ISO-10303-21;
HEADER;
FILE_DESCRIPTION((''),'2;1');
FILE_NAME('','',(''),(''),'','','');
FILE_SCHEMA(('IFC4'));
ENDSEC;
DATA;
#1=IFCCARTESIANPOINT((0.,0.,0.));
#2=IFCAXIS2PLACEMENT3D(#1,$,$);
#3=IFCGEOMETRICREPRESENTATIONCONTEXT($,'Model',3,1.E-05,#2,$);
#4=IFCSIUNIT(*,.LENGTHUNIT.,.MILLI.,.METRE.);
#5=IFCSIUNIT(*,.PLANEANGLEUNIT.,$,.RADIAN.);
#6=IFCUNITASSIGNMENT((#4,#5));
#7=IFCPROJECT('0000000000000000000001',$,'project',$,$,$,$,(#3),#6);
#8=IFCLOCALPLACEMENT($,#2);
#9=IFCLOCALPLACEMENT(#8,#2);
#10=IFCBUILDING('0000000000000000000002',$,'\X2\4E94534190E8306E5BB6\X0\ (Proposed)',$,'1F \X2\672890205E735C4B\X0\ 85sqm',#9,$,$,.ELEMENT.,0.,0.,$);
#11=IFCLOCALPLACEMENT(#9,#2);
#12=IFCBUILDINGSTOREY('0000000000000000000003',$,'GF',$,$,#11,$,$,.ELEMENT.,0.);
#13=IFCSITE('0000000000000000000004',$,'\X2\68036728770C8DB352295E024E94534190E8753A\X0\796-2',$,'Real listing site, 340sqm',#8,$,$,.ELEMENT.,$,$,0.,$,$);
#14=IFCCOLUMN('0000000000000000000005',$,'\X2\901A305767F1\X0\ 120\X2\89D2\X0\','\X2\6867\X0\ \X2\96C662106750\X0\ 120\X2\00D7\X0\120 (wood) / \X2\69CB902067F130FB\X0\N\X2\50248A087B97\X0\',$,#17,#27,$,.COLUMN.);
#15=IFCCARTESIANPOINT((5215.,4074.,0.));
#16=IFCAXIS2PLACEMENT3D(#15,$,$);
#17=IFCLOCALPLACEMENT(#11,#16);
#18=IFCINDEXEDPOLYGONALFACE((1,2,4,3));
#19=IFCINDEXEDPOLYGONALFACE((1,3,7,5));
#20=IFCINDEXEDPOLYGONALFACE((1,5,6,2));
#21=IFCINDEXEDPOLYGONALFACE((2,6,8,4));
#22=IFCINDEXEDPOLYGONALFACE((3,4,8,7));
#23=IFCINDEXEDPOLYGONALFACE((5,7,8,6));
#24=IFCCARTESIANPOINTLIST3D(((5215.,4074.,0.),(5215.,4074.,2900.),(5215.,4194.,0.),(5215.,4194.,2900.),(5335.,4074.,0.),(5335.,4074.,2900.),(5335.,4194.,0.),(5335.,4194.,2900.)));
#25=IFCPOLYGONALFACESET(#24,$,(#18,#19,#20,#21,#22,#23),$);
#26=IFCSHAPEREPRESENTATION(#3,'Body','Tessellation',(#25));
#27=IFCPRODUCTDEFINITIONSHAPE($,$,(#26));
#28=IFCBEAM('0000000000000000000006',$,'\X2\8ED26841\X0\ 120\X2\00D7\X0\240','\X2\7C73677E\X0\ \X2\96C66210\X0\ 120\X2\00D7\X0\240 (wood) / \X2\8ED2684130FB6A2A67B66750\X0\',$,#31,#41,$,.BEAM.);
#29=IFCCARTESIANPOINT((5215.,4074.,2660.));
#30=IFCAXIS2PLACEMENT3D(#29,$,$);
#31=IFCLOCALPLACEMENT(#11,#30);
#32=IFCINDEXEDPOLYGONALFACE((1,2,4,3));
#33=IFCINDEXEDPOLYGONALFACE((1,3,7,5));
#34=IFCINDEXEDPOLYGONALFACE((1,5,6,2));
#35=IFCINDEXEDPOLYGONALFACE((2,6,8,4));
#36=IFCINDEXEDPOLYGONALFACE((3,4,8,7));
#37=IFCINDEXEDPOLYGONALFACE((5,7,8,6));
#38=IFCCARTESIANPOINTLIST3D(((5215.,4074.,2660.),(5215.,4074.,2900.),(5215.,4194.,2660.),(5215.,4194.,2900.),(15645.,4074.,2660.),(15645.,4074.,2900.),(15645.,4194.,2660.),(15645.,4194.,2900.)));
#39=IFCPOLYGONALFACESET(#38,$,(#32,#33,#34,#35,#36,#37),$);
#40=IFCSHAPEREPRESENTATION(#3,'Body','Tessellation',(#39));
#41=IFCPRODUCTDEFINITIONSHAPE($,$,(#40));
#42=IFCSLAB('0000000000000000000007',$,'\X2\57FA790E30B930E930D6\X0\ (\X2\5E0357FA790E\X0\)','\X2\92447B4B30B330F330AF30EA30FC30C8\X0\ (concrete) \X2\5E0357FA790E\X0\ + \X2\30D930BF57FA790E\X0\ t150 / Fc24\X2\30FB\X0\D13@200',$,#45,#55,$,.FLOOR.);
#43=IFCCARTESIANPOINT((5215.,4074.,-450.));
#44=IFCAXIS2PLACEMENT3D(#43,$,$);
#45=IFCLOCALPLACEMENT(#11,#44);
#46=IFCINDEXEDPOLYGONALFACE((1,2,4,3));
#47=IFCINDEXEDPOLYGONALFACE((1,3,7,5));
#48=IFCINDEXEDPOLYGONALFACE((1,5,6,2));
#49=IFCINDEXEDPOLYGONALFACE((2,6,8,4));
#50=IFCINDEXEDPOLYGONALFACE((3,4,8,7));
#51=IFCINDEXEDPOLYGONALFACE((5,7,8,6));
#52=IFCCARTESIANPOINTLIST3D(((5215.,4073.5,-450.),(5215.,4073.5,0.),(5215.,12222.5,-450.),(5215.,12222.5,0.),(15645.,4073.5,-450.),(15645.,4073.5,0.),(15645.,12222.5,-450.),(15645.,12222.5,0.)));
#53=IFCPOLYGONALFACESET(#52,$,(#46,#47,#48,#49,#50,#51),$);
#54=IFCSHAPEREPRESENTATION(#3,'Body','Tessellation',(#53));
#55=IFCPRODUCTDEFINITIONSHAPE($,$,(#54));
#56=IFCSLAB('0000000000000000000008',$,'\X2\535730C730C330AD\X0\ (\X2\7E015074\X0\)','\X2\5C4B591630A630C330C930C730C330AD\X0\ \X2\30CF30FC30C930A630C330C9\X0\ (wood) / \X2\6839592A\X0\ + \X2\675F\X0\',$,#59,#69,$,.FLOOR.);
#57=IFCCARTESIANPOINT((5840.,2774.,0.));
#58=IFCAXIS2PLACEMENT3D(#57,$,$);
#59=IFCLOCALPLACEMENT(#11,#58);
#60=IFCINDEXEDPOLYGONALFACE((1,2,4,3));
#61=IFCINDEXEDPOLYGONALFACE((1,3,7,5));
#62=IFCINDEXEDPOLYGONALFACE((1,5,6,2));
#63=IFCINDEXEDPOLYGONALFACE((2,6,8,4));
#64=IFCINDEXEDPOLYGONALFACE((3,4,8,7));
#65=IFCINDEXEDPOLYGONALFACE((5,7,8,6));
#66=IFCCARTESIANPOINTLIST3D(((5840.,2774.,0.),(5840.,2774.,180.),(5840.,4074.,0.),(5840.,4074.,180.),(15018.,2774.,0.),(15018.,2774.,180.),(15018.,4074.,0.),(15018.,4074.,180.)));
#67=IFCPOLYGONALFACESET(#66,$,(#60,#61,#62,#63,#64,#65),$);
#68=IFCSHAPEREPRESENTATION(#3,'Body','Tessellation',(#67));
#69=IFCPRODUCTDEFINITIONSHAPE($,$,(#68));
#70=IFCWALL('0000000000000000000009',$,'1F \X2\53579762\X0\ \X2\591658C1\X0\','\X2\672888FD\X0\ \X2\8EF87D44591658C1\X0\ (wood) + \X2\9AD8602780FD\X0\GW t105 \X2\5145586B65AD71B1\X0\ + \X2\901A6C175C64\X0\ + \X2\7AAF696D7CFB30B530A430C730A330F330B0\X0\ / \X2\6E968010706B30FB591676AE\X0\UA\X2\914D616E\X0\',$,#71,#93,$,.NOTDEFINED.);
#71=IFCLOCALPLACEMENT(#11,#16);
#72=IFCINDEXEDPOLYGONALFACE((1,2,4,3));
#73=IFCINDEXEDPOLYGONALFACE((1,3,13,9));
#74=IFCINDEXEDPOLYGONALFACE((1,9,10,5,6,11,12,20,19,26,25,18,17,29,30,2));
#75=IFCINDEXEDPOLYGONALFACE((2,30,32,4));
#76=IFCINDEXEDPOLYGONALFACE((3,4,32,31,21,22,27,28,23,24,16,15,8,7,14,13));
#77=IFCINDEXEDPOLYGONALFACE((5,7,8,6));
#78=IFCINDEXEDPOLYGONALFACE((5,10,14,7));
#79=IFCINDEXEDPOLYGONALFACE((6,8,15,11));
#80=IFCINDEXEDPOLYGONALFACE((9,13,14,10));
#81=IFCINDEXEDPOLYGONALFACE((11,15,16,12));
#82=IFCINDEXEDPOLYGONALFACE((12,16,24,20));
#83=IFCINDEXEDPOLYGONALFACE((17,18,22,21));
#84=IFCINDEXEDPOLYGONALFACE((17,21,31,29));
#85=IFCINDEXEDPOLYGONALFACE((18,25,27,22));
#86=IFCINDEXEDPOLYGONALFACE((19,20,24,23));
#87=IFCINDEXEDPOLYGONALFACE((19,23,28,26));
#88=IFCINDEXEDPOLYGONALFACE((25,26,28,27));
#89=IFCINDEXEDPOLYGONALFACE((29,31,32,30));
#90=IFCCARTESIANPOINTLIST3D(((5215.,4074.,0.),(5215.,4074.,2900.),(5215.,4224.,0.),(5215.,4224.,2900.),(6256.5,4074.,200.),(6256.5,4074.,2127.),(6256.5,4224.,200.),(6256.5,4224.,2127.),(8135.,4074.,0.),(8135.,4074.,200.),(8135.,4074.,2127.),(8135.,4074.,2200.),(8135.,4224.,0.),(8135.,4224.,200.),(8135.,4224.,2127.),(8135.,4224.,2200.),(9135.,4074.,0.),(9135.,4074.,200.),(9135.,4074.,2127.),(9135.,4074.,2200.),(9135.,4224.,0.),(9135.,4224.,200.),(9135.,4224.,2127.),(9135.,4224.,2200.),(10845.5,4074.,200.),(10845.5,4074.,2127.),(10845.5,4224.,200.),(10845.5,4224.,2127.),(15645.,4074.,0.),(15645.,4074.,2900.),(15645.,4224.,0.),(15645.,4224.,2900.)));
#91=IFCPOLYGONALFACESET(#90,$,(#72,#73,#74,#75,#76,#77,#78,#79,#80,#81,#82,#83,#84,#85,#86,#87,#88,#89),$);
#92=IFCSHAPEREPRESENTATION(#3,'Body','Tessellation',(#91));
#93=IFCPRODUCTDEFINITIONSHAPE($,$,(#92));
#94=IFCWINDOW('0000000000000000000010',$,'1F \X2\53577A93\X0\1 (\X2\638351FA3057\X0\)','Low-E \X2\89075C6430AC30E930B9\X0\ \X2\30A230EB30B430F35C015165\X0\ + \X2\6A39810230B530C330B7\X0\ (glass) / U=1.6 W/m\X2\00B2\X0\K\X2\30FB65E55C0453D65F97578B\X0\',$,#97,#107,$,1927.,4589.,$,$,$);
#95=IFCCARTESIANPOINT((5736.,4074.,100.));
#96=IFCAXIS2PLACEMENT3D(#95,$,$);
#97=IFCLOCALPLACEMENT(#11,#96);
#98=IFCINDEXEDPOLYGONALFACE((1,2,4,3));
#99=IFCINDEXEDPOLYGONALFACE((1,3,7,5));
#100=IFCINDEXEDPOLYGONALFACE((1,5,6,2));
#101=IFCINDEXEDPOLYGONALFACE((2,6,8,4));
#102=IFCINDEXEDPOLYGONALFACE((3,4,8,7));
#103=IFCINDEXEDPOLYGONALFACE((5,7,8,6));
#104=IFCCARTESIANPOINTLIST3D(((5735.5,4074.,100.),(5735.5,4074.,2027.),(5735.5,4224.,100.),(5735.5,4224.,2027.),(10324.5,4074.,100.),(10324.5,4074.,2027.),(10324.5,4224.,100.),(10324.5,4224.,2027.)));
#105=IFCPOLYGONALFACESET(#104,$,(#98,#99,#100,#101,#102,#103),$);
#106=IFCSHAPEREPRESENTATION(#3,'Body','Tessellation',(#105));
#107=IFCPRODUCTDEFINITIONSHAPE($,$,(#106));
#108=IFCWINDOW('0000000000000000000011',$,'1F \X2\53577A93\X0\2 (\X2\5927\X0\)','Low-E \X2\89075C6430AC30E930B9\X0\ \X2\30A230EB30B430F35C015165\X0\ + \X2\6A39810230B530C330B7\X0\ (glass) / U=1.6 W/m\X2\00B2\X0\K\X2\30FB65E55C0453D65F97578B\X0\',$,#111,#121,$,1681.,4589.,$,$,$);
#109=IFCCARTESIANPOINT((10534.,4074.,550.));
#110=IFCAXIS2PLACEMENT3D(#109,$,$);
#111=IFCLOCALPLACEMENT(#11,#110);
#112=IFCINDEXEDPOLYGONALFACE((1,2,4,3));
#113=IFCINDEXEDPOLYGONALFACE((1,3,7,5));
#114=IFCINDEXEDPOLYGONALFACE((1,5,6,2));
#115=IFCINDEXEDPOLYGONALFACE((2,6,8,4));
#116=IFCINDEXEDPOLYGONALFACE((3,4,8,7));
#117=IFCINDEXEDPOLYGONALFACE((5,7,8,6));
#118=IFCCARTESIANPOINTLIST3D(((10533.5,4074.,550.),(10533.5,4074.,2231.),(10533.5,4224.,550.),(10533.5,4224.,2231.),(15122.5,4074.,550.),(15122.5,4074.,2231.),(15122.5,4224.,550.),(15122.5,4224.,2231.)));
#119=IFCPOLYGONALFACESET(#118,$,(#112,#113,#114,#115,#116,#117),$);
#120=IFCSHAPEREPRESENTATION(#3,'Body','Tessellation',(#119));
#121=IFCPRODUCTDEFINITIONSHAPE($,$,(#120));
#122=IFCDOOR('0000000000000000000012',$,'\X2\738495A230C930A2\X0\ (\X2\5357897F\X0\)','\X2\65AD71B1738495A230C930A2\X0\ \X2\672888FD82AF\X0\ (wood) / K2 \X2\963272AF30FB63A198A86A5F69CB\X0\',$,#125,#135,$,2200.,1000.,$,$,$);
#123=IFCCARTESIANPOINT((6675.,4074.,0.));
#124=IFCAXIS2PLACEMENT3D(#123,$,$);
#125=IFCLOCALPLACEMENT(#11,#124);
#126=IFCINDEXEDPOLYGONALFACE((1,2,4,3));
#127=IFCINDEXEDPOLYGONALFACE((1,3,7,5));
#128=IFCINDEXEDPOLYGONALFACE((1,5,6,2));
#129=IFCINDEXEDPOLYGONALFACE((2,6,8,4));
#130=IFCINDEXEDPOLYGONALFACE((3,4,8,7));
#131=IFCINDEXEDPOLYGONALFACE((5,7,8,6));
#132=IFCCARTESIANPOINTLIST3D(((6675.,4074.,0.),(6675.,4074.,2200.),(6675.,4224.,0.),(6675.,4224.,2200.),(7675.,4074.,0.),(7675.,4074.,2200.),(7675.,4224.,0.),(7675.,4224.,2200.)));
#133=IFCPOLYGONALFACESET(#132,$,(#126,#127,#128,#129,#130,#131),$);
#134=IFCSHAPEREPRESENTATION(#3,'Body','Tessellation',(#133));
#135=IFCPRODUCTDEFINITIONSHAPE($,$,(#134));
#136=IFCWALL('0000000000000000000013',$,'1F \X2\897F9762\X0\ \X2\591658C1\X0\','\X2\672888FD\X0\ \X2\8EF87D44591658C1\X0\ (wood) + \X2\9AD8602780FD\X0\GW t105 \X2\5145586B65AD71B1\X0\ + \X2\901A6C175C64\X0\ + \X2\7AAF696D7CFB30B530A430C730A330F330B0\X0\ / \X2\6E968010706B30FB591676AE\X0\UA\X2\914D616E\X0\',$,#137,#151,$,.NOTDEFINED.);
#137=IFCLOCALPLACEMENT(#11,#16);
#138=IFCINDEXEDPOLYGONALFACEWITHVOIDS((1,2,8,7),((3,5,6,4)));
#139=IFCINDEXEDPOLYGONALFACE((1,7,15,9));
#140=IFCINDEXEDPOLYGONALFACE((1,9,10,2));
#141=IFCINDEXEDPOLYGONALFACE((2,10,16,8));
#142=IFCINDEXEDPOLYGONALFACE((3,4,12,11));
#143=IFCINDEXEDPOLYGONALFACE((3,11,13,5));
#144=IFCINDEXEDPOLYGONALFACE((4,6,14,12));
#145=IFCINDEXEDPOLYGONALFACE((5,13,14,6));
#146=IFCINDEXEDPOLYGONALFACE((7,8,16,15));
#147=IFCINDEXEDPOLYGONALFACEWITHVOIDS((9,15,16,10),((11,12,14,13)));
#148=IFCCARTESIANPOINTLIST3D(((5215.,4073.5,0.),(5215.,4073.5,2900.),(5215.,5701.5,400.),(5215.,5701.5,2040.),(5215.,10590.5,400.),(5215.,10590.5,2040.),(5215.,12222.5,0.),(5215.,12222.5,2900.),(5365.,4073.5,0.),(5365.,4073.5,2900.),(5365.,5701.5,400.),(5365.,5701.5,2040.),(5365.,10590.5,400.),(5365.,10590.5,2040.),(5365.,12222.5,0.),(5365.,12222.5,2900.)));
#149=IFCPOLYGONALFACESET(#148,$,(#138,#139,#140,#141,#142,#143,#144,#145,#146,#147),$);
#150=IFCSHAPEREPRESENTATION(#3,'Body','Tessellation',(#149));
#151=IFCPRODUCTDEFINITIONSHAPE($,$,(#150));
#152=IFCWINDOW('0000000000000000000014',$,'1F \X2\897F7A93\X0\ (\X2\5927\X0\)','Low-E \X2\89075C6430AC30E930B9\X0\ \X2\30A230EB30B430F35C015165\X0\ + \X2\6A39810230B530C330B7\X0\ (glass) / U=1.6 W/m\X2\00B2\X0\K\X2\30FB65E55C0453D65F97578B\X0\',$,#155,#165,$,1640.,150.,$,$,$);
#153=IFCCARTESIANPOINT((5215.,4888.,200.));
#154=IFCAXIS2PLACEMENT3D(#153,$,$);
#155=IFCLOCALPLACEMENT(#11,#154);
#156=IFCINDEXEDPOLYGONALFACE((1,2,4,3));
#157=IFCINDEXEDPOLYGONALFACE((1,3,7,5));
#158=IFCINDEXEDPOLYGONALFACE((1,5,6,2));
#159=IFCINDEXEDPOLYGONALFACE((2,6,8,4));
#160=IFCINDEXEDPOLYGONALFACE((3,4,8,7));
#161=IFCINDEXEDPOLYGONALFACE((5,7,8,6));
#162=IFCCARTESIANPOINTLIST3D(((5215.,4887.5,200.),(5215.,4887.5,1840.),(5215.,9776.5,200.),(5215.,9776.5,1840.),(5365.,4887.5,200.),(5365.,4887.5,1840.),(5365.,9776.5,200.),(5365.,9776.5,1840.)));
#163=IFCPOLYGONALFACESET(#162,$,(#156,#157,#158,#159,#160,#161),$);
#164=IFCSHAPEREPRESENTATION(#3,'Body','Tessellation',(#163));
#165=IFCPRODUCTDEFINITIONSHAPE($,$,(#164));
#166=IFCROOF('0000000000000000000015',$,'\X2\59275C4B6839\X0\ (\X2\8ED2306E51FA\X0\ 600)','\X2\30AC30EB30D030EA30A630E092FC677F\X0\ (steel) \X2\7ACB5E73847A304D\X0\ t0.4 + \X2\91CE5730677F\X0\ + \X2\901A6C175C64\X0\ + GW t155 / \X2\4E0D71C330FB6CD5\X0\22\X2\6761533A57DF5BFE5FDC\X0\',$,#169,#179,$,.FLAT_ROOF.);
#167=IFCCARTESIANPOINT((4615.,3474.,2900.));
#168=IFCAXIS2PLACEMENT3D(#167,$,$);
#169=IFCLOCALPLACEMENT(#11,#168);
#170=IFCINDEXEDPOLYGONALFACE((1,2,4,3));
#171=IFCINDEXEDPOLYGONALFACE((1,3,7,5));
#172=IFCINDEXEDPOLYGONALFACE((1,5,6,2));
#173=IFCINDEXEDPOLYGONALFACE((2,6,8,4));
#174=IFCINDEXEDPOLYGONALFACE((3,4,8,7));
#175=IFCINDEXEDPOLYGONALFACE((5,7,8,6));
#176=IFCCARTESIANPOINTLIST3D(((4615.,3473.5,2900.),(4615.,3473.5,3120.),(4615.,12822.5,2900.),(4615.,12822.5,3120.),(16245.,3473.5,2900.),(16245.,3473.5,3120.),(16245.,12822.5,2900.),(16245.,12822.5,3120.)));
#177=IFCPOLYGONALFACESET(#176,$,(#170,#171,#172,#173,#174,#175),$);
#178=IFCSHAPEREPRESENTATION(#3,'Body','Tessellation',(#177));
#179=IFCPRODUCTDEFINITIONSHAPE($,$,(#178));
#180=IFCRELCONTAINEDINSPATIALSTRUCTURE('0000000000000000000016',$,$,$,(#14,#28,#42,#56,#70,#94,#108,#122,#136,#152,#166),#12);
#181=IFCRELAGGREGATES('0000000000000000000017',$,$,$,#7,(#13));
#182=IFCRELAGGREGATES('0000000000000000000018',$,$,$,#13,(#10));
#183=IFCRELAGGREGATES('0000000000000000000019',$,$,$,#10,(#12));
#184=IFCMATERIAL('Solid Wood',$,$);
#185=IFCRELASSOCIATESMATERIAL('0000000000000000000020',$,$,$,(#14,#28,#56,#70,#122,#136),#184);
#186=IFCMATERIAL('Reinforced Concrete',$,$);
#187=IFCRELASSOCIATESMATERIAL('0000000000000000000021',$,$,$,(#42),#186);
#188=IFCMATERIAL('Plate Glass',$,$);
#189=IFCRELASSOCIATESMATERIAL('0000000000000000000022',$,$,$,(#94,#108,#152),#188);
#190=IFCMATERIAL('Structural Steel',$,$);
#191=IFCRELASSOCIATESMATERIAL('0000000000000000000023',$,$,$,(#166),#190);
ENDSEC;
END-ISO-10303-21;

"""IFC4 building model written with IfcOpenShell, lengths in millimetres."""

from ifc_helpers import new_model, si_unit, frame, frame_2d, origin, place, context, project, spatial, rectangle, extrude, material, element, fill, save


model = new_model("IFC4")

# Units and contexts
model_context = context("Model", 3, precision=1e-05, world=origin())
ifc_project = project(units=[si_unit("LENGTHUNIT", "METRE", prefix="MILLI"), si_unit("PLANEANGLEUNIT", "RADIAN")], contexts=[model_context])

# Site, building, storey
site_placement = place(None, origin())
site = spatial("IfcSite", under=ifc_project, at=site_placement, Name="栃木県足利市五十部町796-2", ObjectType="Real listing site, 340sqm", CompositionType="ELEMENT", RefElevation=0.0)
building_placement = place(site_placement, origin())
building = spatial("IfcBuilding", under=site, at=building_placement, Name="五十部の家 (Proposed)", ObjectType="1F 木造平屋 85sqm", CompositionType="ELEMENT", ElevationOfRefHeight=0.0, ElevationOfTerrain=0.0)
storey_placement = place(building_placement, origin())
storey = spatial("IfcBuildingStorey", under=building, at=storey_placement, Name="GF", CompositionType="ELEMENT", Elevation=0.0)

# Column
ifc_material_1 = material(Name="Solid Wood")
column_1_placement = place(storey_placement, frame((5215.0, 4074.0, 0.0)))
element("IfcColumn", 1, at=column_1_placement, inside=storey, material=ifc_material_1, Name="通し柱 120角", Description="桧 集成材 120×120 (wood) / 構造柱・N値計算", PredefinedType="COLUMN", context=model_context, shape_type="SweptSolid", body=[
    extrude(rectangle(XDim=120.0, YDim=120.0, at=frame_2d((60.0, 60.0))), frame((5215.0, 4074.0, 0.0)), (0.0, 0.0, 1.0), 2900.0),
])

# Beam
beam_1_placement = place(storey_placement, frame((5215.0, 4074.0, 2660.0)))
element("IfcBeam", 2, at=beam_1_placement, inside=storey, material=ifc_material_1, Name="軒桁 120×240", Description="米松 集成 120×240 (wood) / 軒桁・横架材", PredefinedType="BEAM", context=model_context, shape_type="SweptSolid", body=[
    extrude(rectangle(XDim=10430.0, YDim=120.0, at=frame_2d((5215.0, 60.0))), frame((5215.0, 4074.0, 2660.0)), (0.0, 0.0, 1.0), 240.0),
])

# Slabs
ifc_material_2 = material(Name="Reinforced Concrete")
slab_1_placement = place(storey_placement, frame((5215.0, 4074.0, -450.0)))
element("IfcSlab", 3, at=slab_1_placement, inside=storey, material=ifc_material_2, Name="基礎スラブ (布基礎)", Description="鉄筋コンクリート (concrete) 布基礎 + ベタ基礎 t150 / Fc24・D13@200", PredefinedType="FLOOR", context=model_context, shape_type="SweptSolid", body=[
    extrude(rectangle(XDim=10430.0, YDim=8149.0, at=frame_2d((5215.0, 4074.0))), frame((5215.0, 4074.0, -450.0)), (0.0, 0.0, 1.0), 450.0),
])
slab_2_placement = place(storey_placement, frame((5840.0, 2774.0, 0.0)))
element("IfcSlab", 4, at=slab_2_placement, inside=storey, material=ifc_material_1, Name="南デッキ (縁側)", Description="屋外ウッドデッキ ハードウッド (wood) / 根太 + 束", PredefinedType="FLOOR", context=model_context, shape_type="SweptSolid", body=[
    extrude(rectangle(XDim=9178.0, YDim=1300.0, at=frame_2d((4589.0, 650.0))), frame((5840.0, 2774.0, 0.0)), (0.0, 0.0, 1.0), 180.0),
])

# Wall, openings, windows, door
wall_1_placement = place(storey_placement, frame((5215.0, 4074.0, 0.0)))
wall_1 = element("IfcWall", 5, at=wall_1_placement, inside=storey, material=ifc_material_1, Name="1F 南面 外壁", Description="木製 軸組外壁 (wood) + 高性能GW t105 充填断熱 + 通気層 + 窯業系サイディング / 準耐火・外皮UA配慮", PredefinedType="NOTDEFINED", context=model_context, shape_type="SweptSolid", body=[
    extrude(rectangle(XDim=10430.0, YDim=150.0, at=frame_2d((5215.0, 75.0))), frame((5215.0, 4074.0, 0.0)), (0.0, 0.0, 1.0), 2900.0),
])
opening_1_placement = place(storey_placement, frame((5736.0, 4074.0, 100.0)))
opening_1 = element("IfcOpeningElement", 6, at=opening_1_placement, cuts=wall_1, PredefinedType="NOTDEFINED", context=model_context, shape_type="SweptSolid", body=[
    extrude(rectangle(XDim=4589.0, YDim=150.0, at=frame_2d((2294.0, 75.0))), frame((5736.0, 4074.0, 100.0)), (0.0, 0.0, 1.0), 1927.0),
])
opening_2_placement = place(storey_placement, frame((10534.0, 4074.0, 550.0)))
opening_2 = element("IfcOpeningElement", 7, at=opening_2_placement, cuts=wall_1, PredefinedType="NOTDEFINED", context=model_context, shape_type="SweptSolid", body=[
    extrude(rectangle(XDim=4589.0, YDim=150.0, at=frame_2d((2294.0, 75.0))), frame((10534.0, 4074.0, 550.0)), (0.0, 0.0, 1.0), 1681.0),
])
opening_3_placement = place(storey_placement, frame((6675.0, 4074.0, 0.0)))
opening_3 = element("IfcOpeningElement", 8, at=opening_3_placement, cuts=wall_1, PredefinedType="NOTDEFINED", context=model_context, shape_type="SweptSolid", body=[
    extrude(rectangle(XDim=1000.0, YDim=150.0, at=frame_2d((500.0, 75.0))), frame((6675.0, 4074.0, 0.0)), (0.0, 0.0, 1.0), 2200.0),
])
ifc_material_3 = material(Name="Plate Glass")
window_1_placement = place(storey_placement, frame((5736.0, 4074.0, 100.0)))
window_1 = element("IfcWindow", 9, at=window_1_placement, inside=storey, material=ifc_material_3, Name="1F 南窓1 (掃出し)", Description="Low-E 複層ガラス アルゴン封入 + 樹脂サッシ (glass) / U=1.6 W/m²K・日射取得型", OverallHeight=1927.0, OverallWidth=4589.0, context=model_context, shape_type="SweptSolid", body=[
    extrude(rectangle(XDim=4589.0, YDim=150.0, at=frame_2d((2294.0, 75.0))), frame((5736.0, 4074.0, 100.0)), (0.0, 0.0, 1.0), 1927.0),
])
fill(opening_1, window_1)
window_2_placement = place(storey_placement, frame((10534.0, 4074.0, 550.0)))
window_2 = element("IfcWindow", 10, at=window_2_placement, inside=storey, material=ifc_material_3, Name="1F 南窓2 (大)", Description="Low-E 複層ガラス アルゴン封入 + 樹脂サッシ (glass) / U=1.6 W/m²K・日射取得型", OverallHeight=1681.0, OverallWidth=4589.0, context=model_context, shape_type="SweptSolid", body=[
    extrude(rectangle(XDim=4589.0, YDim=150.0, at=frame_2d((2294.0, 75.0))), frame((10534.0, 4074.0, 550.0)), (0.0, 0.0, 1.0), 1681.0),
])
fill(opening_2, window_2)
door_placement = place(storey_placement, frame((6675.0, 4074.0, 0.0)))
door = element("IfcDoor", 11, at=door_placement, inside=storey, material=ifc_material_1, Name="玄関ドア (南西)", Description="断熱玄関ドア 木製芯 (wood) / K2 防犯・採風機構", OverallHeight=2200.0, OverallWidth=1000.0, context=model_context, shape_type="SweptSolid", body=[
    extrude(rectangle(XDim=1000.0, YDim=150.0, at=frame_2d((500.0, 75.0))), frame((6675.0, 4074.0, 0.0)), (0.0, 0.0, 1.0), 2200.0),
])
fill(opening_3, door)

# Wall, opening, window
wall_2_placement = place(storey_placement, frame((5215.0, 4074.0, 0.0)))
wall_2 = element("IfcWall", 12, at=wall_2_placement, inside=storey, material=ifc_material_1, Name="1F 西面 外壁", Description="木製 軸組外壁 (wood) + 高性能GW t105 充填断熱 + 通気層 + 窯業系サイディング / 準耐火・外皮UA配慮", PredefinedType="NOTDEFINED", context=model_context, shape_type="SweptSolid", body=[
    extrude(rectangle(XDim=150.0, YDim=8149.0, at=frame_2d((75.0, 4074.0))), frame((5215.0, 4074.0, 0.0)), (0.0, 0.0, 1.0), 2900.0),
])
opening_4_placement = place(storey_placement, frame((5215.0, 4888.0, 200.0)))
opening_4 = element("IfcOpeningElement", 13, at=opening_4_placement, cuts=wall_2, PredefinedType="NOTDEFINED", context=model_context, shape_type="SweptSolid", body=[
    extrude(rectangle(XDim=150.0, YDim=4889.0, at=frame_2d((75.0, 2444.0))), frame((5215.0, 4888.0, 200.0)), (0.0, 0.0, 1.0), 1640.0),
])
window_3_placement = place(storey_placement, frame((5215.0, 4888.0, 200.0)))
window_3 = element("IfcWindow", 14, at=window_3_placement, inside=storey, material=ifc_material_3, Name="1F 西窓 (大)", Description="Low-E 複層ガラス アルゴン封入 + 樹脂サッシ (glass) / U=1.6 W/m²K・日射取得型", OverallHeight=1640.0, OverallWidth=150.0, context=model_context, shape_type="SweptSolid", body=[
    extrude(rectangle(XDim=150.0, YDim=4889.0, at=frame_2d((75.0, 2444.0))), frame((5215.0, 4888.0, 200.0)), (0.0, 0.0, 1.0), 1640.0),
])
fill(opening_4, window_3)

# Roof
ifc_material_4 = material(Name="Structural Steel")
roof_placement = place(storey_placement, frame((4615.0, 3474.0, 2900.0)))
element("IfcRoof", 15, at=roof_placement, inside=storey, material=ifc_material_4, Name="大屋根 (軒の出 600)", Description="ガルバリウム鋼板 (steel) 立平葺き t0.4 + 野地板 + 通気層 + GW t155 / 不燃・法22条区域対応", PredefinedType="FLAT_ROOF", context=model_context, shape_type="SweptSolid", body=[
    extrude(rectangle(XDim=11630.0, YDim=9349.0, at=frame_2d((5815.0, 4674.0))), frame((4615.0, 3474.0, 2900.0)), (0.0, 0.0, 1.0), 220.0),
])

save(model, "model.ifc")
